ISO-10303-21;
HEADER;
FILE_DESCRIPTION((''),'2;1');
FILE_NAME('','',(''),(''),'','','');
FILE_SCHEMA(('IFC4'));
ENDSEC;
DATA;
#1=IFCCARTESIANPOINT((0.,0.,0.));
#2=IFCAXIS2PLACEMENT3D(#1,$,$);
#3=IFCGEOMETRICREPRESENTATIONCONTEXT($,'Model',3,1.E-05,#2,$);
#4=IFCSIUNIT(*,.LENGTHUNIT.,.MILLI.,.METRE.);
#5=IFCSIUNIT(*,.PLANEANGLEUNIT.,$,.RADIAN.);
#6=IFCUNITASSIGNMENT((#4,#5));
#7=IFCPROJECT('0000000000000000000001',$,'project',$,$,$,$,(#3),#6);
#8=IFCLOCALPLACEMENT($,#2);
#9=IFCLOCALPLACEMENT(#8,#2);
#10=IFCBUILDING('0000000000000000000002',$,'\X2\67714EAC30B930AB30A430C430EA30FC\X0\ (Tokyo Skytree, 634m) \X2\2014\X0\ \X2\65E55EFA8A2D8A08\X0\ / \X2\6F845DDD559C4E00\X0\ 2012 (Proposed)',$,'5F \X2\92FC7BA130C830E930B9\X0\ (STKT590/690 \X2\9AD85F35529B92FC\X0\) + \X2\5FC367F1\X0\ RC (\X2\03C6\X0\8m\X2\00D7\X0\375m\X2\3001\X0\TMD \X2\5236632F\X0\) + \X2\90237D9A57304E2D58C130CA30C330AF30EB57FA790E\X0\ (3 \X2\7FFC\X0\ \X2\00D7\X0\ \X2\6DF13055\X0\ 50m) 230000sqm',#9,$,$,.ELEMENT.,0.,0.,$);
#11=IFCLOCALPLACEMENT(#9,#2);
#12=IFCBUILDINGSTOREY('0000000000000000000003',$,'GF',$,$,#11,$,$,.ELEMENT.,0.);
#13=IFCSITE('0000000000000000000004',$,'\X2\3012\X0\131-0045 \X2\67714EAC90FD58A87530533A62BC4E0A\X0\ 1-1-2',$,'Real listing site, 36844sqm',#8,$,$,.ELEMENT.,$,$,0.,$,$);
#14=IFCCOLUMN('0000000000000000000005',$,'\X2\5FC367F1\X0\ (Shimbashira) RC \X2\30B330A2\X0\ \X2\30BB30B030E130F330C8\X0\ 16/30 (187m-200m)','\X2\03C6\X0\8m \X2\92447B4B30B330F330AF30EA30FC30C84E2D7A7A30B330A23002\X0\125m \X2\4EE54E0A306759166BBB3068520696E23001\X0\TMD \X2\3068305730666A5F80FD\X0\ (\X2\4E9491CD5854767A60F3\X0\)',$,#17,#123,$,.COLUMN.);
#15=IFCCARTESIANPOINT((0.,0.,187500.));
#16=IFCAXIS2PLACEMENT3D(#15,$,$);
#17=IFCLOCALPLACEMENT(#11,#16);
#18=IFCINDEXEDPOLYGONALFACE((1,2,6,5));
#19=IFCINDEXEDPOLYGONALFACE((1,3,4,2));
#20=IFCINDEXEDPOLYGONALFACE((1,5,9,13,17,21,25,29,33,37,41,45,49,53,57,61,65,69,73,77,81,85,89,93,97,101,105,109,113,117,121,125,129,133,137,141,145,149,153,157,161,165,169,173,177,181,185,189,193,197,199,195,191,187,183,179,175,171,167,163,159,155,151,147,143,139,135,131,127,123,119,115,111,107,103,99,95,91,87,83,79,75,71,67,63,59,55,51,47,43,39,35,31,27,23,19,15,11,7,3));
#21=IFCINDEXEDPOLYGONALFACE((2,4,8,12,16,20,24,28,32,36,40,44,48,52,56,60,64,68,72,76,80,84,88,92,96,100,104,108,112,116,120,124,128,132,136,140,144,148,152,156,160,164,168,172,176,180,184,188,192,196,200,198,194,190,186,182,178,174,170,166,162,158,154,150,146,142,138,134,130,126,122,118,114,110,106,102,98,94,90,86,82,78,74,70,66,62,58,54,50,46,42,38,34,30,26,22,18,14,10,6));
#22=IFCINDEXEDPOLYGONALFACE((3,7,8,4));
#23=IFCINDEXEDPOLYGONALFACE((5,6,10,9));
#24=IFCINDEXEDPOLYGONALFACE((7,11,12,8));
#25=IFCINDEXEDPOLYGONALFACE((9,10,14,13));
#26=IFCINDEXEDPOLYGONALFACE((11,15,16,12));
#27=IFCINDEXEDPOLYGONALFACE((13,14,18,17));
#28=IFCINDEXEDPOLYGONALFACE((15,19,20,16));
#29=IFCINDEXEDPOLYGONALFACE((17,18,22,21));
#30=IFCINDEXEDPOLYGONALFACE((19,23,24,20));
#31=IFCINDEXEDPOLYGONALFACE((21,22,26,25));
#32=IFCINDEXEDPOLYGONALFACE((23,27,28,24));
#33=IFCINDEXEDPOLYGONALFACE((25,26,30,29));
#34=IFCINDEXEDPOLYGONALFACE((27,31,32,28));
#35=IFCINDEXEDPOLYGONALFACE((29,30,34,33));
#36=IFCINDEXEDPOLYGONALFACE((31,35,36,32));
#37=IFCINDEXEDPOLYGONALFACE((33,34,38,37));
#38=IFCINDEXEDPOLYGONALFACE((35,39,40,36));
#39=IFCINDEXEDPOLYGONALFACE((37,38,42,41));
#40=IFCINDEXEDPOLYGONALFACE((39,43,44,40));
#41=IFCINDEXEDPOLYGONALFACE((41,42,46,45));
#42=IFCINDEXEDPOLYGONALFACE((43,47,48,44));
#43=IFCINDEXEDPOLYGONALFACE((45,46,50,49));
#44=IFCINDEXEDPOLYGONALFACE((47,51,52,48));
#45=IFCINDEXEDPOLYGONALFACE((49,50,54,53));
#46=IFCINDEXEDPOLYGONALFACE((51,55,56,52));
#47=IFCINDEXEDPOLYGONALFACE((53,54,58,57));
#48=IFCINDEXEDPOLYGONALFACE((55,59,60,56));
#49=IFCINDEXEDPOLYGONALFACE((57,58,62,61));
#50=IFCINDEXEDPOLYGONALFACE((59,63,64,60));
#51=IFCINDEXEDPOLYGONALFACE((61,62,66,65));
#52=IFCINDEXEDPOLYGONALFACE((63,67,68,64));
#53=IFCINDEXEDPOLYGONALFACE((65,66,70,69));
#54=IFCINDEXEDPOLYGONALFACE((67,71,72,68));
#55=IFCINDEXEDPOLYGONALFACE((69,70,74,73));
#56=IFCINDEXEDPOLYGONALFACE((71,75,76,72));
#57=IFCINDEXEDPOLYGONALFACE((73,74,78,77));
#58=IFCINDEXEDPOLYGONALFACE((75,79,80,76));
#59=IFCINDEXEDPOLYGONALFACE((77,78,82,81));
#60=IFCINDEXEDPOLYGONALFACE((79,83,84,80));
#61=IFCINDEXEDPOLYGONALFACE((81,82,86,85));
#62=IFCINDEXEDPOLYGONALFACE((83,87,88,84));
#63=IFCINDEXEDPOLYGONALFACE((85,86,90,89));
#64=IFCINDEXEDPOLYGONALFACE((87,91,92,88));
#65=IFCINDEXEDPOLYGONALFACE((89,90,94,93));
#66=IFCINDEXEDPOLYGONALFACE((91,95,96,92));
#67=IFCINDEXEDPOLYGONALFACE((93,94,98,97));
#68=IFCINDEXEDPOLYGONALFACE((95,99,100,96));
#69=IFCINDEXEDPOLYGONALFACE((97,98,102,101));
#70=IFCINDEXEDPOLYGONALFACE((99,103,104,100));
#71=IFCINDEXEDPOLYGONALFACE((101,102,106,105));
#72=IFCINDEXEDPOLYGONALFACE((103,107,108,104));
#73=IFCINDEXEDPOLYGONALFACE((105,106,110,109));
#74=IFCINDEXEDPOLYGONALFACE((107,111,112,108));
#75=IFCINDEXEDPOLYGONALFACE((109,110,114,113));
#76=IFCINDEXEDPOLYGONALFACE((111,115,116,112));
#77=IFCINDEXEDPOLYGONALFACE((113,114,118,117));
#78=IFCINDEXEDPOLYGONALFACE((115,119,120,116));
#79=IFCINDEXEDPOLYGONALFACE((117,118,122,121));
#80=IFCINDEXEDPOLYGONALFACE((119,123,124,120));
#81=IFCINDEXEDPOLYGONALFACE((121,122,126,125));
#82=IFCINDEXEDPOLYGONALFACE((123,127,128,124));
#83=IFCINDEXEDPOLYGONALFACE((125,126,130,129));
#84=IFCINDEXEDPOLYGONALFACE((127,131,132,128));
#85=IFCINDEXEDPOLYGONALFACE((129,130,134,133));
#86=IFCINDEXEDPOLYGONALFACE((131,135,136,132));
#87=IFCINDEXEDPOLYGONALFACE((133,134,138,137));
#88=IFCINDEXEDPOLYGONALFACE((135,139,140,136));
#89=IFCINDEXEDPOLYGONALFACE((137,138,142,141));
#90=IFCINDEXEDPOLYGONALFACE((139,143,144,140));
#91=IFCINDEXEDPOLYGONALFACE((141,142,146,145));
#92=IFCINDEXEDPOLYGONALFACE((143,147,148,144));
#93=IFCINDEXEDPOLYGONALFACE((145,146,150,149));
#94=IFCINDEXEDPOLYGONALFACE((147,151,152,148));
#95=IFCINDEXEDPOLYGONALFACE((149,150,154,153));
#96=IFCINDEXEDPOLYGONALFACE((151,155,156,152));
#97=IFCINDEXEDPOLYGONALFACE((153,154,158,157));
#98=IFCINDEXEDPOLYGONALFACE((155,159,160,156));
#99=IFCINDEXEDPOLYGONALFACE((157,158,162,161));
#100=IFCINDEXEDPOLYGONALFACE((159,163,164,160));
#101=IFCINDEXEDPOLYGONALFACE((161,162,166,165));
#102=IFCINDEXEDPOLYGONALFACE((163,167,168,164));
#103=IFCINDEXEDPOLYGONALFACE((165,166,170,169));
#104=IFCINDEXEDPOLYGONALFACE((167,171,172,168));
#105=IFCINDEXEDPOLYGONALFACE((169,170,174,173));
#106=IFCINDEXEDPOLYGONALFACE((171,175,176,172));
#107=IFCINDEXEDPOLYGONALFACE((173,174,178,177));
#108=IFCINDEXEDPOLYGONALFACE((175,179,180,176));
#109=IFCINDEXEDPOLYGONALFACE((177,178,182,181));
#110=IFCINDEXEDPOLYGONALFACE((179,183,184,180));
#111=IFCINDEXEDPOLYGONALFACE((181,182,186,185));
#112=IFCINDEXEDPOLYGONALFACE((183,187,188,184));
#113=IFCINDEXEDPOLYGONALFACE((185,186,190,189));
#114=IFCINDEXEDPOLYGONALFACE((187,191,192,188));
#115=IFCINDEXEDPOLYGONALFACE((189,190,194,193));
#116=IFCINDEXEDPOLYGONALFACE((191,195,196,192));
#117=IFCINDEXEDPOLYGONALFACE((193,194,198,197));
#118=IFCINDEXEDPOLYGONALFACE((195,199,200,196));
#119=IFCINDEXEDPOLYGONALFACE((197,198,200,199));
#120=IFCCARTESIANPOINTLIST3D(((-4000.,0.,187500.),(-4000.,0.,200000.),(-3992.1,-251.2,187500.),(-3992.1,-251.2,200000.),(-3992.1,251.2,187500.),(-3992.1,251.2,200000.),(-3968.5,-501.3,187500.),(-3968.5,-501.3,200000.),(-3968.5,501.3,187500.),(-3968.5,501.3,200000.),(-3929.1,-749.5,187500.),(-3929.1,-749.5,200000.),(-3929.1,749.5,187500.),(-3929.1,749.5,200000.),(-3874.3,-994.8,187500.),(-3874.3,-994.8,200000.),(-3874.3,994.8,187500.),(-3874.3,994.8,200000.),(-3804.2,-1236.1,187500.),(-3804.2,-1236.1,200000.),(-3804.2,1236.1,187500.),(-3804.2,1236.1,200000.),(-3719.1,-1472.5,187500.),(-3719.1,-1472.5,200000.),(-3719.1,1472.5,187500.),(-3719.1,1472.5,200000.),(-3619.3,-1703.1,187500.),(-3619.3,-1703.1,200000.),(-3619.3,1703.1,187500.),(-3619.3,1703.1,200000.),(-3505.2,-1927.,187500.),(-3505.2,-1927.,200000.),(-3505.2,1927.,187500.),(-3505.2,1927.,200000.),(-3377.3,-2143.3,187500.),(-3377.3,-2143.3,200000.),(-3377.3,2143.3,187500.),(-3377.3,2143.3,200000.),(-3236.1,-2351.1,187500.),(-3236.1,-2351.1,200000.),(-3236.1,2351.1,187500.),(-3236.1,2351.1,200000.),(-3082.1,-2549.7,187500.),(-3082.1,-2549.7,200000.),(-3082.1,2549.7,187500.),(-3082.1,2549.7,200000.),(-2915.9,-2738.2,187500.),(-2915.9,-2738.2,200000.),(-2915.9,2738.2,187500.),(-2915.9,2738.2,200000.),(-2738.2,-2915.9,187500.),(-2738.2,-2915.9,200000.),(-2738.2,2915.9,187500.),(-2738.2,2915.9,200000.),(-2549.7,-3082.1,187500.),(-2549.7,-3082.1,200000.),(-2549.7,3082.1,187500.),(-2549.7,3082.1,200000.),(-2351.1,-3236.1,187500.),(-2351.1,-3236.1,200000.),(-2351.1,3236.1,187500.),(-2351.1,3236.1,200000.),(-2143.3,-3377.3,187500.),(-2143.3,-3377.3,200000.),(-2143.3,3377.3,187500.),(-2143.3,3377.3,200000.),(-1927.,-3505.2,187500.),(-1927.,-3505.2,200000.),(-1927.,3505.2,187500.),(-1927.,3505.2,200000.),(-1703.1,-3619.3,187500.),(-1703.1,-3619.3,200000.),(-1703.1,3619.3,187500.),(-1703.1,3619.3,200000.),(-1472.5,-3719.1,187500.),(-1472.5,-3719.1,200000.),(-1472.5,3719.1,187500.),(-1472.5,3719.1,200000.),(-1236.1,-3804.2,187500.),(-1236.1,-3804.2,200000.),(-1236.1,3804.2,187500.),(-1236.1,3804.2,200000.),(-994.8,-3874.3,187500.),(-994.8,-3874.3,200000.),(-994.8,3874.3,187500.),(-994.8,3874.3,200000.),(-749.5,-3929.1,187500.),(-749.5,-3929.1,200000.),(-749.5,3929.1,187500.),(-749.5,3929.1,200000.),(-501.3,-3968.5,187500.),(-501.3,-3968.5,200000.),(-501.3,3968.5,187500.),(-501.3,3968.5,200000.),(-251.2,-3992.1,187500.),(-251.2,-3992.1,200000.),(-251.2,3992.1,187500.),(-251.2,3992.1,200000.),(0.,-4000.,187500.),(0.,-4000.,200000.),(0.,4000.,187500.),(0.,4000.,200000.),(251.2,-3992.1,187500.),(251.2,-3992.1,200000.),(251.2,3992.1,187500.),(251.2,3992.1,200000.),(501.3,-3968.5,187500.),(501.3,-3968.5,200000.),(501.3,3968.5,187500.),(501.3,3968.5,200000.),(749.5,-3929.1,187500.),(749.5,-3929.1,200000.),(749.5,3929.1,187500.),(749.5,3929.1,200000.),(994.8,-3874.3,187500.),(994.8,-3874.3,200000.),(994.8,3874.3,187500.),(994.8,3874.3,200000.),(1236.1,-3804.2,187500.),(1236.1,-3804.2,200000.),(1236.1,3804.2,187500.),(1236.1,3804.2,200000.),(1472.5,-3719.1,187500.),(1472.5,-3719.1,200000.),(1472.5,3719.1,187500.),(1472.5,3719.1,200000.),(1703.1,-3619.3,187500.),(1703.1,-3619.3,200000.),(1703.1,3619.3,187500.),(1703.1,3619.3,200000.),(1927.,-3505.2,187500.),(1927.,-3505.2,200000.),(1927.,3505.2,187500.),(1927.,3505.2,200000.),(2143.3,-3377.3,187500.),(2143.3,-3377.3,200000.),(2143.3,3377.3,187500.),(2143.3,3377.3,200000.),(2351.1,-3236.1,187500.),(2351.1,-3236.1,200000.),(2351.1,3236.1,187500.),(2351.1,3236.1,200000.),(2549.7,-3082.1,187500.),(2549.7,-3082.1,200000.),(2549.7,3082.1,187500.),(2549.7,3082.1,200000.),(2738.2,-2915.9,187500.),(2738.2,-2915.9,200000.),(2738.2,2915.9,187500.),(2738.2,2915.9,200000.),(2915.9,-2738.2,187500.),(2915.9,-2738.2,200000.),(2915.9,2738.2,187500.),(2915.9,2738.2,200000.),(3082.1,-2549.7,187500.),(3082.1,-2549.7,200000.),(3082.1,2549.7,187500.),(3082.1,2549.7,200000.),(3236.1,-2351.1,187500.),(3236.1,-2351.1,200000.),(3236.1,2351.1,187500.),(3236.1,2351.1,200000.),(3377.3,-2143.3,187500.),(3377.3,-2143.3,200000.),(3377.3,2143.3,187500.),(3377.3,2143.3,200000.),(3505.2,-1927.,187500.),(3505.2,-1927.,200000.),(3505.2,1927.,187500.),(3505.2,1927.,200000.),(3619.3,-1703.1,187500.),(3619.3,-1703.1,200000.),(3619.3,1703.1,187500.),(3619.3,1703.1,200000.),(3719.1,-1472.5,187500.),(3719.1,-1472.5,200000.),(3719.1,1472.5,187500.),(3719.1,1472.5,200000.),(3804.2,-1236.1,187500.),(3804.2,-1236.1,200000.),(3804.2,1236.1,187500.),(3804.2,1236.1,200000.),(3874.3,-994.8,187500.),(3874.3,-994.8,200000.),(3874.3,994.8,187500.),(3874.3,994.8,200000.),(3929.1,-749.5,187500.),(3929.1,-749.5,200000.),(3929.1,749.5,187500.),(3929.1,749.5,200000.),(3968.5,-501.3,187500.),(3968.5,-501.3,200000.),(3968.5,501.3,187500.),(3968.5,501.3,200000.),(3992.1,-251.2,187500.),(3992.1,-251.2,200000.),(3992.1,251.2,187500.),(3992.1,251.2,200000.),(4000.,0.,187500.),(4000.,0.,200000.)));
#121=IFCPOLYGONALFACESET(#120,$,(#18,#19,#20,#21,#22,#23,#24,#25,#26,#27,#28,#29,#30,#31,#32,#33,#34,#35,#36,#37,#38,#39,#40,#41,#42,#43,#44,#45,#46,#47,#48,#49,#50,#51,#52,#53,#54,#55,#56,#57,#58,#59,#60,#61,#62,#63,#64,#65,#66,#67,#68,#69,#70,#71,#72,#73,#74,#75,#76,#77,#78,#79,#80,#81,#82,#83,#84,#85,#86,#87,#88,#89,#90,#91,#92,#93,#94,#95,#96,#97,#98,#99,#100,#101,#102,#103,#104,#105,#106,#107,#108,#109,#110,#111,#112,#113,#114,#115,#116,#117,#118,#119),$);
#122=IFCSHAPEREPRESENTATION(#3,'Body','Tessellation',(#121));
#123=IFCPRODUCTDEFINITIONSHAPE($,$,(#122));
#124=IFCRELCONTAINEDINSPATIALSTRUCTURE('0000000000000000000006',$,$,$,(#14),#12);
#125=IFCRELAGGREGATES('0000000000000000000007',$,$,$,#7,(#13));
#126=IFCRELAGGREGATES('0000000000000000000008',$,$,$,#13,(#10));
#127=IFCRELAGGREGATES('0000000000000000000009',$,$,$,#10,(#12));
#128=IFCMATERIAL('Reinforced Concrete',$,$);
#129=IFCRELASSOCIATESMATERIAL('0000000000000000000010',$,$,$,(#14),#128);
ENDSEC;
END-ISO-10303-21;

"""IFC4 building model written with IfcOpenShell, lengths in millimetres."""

from ifc_helpers import new_model, si_unit, frame, origin, origin_2d, place, context, project, spatial, circle, extrude, material, element, save


model = new_model("IFC4")

# Units and contexts
model_context = context("Model", 3, precision=1e-05, world=origin())
ifc_project = project(units=[si_unit("LENGTHUNIT", "METRE", prefix="MILLI"), si_unit("PLANEANGLEUNIT", "RADIAN")], contexts=[model_context])

# Site, building, storey
site_placement = place(None, origin())
site = spatial("IfcSite", under=ifc_project, at=site_placement, Name="〒131-0045 東京都墨田区押上 1-1-2", ObjectType="Real listing site, 36844sqm", CompositionType="ELEMENT", RefElevation=0.0)
building_placement = place(site_placement, origin())
building = spatial("IfcBuilding", under=site, at=building_placement, Name="東京スカイツリー (Tokyo Skytree, 634m) — 日建設計 / 澄川喜一 2012 (Proposed)", ObjectType="5F 鋼管トラス (STKT590/690 高張力鋼) + 心柱 RC (φ8m×375m、TMD 制振) + 連続地中壁ナックル基礎 (3 翼 × 深さ 50m) 230000sqm", CompositionType="ELEMENT", ElevationOfRefHeight=0.0, ElevationOfTerrain=0.0)
storey_placement = place(building_placement, origin())
storey = spatial("IfcBuildingStorey", under=building, at=storey_placement, Name="GF", CompositionType="ELEMENT", Elevation=0.0)

# Column
ifc_material_1 = material(Name="Reinforced Concrete")
column_1_placement = place(storey_placement, frame((0.0, 0.0, 187500.0)))
element("IfcColumn", 1, at=column_1_placement, inside=storey, material=ifc_material_1, Name="心柱 (Shimbashira) RC コア セグメント 16/30 (187m-200m)", Description="φ8m 鉄筋コンクリート中空コア。125m 以上で外殻と分離、TMD として機能 (五重塔発想)", PredefinedType="COLUMN", context=model_context, shape_type="SweptSolid", body=[
    extrude(circle(Radius=4000.0, at=origin_2d()), frame((0.0, 0.0, 187500.0)), (0.0, 0.0, 1.0), 12500.0),
])

save(model, "model.ifc")
